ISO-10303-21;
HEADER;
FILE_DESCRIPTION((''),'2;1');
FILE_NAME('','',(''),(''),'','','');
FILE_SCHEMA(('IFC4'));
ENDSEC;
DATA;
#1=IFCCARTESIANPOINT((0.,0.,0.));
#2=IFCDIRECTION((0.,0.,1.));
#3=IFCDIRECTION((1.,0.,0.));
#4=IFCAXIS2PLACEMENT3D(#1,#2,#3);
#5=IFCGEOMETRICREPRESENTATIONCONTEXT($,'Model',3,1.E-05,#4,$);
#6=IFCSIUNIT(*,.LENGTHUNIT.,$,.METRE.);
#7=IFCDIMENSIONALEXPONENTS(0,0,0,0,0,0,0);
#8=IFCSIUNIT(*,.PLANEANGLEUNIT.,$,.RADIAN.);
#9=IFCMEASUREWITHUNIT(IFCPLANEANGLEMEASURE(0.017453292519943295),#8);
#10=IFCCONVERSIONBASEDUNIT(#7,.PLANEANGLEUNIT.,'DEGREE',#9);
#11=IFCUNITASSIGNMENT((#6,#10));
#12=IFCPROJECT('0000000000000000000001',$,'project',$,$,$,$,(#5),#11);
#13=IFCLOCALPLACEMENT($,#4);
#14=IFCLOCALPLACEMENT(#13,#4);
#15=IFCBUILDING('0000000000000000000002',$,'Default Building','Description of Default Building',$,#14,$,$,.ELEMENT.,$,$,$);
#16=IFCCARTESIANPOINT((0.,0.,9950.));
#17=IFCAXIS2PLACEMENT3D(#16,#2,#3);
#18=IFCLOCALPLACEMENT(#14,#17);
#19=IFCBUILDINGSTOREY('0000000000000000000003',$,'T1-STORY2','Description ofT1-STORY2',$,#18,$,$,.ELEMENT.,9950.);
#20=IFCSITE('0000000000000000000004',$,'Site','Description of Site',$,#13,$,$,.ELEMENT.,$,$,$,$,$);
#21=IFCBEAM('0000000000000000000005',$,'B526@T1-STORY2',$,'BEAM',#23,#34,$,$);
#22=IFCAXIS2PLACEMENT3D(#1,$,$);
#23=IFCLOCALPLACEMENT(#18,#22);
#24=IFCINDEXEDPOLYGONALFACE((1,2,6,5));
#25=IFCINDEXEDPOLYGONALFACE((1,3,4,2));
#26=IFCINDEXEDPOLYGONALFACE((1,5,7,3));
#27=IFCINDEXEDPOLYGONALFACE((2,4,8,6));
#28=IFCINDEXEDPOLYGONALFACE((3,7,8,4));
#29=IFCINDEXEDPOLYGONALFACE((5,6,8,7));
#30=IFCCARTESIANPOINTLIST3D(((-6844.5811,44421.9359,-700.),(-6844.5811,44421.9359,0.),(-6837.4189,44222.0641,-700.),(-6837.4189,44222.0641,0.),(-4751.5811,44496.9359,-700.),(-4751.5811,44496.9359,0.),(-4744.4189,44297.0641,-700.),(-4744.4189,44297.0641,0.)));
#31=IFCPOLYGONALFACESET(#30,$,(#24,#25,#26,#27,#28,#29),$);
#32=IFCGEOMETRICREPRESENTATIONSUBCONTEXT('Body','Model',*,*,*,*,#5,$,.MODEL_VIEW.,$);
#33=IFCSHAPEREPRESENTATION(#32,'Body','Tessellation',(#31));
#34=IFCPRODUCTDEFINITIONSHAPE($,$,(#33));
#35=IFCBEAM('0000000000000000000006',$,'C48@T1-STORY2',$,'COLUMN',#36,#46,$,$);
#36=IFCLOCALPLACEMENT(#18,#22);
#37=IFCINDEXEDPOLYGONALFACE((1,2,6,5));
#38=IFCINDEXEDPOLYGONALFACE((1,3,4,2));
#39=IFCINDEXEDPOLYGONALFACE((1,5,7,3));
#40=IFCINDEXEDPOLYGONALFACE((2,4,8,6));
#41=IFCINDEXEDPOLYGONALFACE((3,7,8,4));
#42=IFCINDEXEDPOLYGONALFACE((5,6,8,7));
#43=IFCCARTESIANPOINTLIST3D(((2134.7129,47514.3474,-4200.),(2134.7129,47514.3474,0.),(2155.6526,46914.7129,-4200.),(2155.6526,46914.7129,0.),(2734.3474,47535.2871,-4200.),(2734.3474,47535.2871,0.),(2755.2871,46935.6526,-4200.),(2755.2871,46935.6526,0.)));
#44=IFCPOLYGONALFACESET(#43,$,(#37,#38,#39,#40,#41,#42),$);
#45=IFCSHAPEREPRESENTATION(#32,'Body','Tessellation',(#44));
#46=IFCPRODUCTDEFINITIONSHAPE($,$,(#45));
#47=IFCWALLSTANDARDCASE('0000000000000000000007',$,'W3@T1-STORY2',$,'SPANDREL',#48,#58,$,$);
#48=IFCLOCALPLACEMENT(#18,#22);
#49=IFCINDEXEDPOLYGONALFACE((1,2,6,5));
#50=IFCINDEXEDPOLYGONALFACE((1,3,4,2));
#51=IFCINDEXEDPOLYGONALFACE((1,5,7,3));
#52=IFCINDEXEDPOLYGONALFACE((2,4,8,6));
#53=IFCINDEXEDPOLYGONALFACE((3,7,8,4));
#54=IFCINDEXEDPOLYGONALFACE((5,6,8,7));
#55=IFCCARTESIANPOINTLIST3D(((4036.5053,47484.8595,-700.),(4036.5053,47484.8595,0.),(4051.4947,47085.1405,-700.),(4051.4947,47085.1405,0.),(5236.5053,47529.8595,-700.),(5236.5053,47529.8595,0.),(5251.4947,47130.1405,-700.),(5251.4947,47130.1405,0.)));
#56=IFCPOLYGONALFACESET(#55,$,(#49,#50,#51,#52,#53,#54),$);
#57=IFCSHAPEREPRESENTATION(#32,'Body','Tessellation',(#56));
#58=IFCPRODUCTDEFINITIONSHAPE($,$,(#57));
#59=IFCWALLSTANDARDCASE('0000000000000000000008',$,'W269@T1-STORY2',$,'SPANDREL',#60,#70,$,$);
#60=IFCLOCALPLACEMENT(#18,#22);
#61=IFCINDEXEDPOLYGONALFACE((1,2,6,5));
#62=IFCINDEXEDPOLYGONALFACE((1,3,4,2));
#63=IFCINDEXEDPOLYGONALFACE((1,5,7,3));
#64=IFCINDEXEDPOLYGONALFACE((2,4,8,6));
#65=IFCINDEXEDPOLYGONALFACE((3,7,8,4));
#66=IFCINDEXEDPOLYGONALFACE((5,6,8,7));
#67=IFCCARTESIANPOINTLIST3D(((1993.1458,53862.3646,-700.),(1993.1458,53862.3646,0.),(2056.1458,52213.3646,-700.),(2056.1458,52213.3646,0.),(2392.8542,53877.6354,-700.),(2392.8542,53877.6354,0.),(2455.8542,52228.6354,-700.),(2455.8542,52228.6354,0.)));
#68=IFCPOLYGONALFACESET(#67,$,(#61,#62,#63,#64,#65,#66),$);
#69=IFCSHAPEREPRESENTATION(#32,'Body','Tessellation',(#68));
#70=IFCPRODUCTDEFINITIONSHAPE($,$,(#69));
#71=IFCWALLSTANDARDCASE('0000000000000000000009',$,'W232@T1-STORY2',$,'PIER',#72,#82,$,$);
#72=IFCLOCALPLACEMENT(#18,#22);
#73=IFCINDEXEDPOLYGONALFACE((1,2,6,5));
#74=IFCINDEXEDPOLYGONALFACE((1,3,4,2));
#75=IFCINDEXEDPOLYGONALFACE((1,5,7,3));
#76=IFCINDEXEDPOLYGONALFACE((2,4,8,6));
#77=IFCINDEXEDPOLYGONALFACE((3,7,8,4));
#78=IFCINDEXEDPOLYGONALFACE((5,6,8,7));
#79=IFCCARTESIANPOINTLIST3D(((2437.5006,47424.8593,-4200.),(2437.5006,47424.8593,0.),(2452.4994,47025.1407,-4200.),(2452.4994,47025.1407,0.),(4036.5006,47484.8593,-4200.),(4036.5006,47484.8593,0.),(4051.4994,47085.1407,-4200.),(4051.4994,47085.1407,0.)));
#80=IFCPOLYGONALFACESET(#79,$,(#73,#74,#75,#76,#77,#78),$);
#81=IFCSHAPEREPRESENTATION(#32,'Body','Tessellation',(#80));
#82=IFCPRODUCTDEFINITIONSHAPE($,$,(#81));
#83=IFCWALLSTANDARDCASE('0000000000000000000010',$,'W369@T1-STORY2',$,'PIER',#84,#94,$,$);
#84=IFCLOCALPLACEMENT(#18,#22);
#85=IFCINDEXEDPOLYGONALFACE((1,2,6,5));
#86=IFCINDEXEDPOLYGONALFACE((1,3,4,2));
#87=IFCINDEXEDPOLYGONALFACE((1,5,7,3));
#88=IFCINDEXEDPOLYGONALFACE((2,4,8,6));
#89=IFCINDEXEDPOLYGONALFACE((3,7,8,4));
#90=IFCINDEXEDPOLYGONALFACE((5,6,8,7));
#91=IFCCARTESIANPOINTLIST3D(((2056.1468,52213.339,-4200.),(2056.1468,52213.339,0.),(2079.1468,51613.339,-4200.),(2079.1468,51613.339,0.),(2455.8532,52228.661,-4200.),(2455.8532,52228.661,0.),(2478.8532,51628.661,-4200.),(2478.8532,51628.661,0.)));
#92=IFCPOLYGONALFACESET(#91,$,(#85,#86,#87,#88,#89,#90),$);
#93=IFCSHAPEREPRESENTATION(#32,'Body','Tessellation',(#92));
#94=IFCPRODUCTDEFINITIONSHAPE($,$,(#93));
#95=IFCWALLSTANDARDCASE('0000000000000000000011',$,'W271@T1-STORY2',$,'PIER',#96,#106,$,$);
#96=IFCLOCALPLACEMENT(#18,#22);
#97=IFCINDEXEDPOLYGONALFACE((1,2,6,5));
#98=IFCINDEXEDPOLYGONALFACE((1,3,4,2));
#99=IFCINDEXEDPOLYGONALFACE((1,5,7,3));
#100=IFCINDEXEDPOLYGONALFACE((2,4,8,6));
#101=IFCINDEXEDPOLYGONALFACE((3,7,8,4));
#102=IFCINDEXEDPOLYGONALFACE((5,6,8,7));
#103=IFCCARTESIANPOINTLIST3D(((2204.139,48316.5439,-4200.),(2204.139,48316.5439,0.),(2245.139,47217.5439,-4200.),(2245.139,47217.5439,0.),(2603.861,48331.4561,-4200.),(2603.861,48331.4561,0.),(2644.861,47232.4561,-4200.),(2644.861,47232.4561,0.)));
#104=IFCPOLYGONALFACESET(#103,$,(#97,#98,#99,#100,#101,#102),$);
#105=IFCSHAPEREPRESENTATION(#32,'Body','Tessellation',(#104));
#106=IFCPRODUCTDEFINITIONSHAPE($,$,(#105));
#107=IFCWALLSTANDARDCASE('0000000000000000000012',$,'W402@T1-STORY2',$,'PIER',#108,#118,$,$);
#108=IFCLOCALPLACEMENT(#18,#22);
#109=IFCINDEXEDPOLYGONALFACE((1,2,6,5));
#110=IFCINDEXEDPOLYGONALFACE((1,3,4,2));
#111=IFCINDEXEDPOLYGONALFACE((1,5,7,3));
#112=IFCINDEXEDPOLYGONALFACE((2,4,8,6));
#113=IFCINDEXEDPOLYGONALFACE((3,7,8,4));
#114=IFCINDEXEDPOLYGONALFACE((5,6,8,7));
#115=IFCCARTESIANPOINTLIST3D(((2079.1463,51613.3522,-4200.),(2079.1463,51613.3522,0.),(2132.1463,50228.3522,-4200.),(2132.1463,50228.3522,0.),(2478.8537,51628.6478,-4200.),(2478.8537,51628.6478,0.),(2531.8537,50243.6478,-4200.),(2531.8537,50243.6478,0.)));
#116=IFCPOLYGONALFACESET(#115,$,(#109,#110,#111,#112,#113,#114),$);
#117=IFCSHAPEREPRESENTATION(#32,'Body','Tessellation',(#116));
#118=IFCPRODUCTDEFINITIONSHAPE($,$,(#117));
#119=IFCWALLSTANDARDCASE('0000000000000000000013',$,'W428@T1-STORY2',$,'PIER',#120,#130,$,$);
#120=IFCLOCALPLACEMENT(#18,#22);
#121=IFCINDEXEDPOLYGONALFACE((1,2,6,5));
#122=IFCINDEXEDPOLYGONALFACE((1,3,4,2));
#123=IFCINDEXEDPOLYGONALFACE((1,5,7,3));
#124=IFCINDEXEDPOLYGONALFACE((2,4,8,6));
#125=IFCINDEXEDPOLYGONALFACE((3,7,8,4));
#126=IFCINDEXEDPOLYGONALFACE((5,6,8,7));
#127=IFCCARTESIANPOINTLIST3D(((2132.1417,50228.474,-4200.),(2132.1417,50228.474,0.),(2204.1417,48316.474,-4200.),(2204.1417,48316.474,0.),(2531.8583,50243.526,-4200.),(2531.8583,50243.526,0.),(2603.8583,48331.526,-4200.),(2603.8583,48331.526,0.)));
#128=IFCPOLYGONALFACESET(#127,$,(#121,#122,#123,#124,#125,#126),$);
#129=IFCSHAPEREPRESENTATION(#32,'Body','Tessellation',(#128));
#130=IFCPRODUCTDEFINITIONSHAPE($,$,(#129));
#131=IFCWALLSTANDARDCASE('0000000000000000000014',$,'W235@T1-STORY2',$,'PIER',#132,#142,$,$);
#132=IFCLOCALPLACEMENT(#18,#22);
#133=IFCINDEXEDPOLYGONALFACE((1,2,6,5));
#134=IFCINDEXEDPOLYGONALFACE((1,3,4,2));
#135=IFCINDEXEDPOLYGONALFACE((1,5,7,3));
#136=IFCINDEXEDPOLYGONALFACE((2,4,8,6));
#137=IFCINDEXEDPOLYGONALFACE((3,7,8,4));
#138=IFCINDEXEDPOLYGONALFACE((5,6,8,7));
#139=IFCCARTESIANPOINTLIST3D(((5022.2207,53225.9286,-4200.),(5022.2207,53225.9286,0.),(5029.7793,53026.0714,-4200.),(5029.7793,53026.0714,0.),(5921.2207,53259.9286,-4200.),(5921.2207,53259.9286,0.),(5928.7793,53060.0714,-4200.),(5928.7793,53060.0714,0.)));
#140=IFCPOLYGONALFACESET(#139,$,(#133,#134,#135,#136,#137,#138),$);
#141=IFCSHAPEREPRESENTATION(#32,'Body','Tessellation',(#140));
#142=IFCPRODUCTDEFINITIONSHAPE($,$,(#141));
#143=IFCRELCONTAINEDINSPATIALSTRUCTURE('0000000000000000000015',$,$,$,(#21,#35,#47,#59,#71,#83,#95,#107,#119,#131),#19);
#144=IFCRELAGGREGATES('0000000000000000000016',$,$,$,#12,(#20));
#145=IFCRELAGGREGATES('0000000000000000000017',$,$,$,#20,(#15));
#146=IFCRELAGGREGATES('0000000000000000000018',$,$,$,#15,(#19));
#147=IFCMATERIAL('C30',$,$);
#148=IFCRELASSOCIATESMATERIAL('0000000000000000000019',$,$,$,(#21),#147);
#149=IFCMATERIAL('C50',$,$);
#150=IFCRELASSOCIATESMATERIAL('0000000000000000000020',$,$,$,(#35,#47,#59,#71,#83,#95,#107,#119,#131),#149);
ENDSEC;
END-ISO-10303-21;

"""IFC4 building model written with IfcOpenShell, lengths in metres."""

from ifc_helpers import new_model, entity, si_unit, converted_unit, frame, origin_with_axes, place, context, subcontext, project, spatial, indexed_curve, rectangle, outline, extrude, material, element, save


model = new_model("IFC4")

# Units and contexts
model_context = context("Model", 3, precision=1e-05, world=origin_with_axes())
body_context = subcontext(model_context, "Body", "Model", "MODEL_VIEW")
ifc_project = project(units=[si_unit("LENGTHUNIT", "METRE"), converted_unit("PLANEANGLEUNIT", "DEGREE", entity("IfcPlaneAngleMeasure", 0.017453292519943295), si_unit("PLANEANGLEUNIT", "RADIAN"), dimensions=[0, 0, 0, 0, 0, 0, 0])], contexts=[model_context])

# Site, building, storey
site_placement = place(None, origin_with_axes())
site = spatial("IfcSite", under=ifc_project, at=site_placement, Name="Site", Description="Description of Site", CompositionType="ELEMENT")
building_placement = place(site_placement, origin_with_axes())
building = spatial("IfcBuilding", under=site, at=building_placement, Name="Default Building", Description="Description of Default Building", CompositionType="ELEMENT")
storey_placement = place(building_placement, frame((0.0, 0.0, 9950.0), z_axis=(0.0, 0.0, 1.0), x_axis=(1.0, 0.0, 0.0)))
storey = spatial("IfcBuildingStorey", under=building, at=storey_placement, Name="T1-STORY2", Description="Description ofT1-STORY2", CompositionType="ELEMENT", Elevation=9950.0)

# Beams
ifc_material_1 = material(Name="C30")
beam_1_placement = place(storey_placement, frame((-6841.0, 44322.0, -350.0), z_axis=(0.999359, 0.035811, 0.0), x_axis=(-0.035811, 0.999359, 0.0)))
element("IfcBeam", 1, at=beam_1_placement, inside=storey, material=ifc_material_1, Name="B526@T1-STORY2", ObjectType="BEAM", context=body_context, shape_type="SweptSolid", body=[
    extrude(rectangle(XDim=200.0, YDim=700.0), origin_with_axes(), (0.0, 0.0, 1.0), 2094.3433),
])
ifc_material_2 = material(Name="C50")
beam_2_placement = place(storey_placement, frame((2445.0, 47225.0, -4200.0), z_axis=(0.0, 0.0, 1.0), x_axis=(-0.999391, -0.034899, 0.0)))
element("IfcBeam", 2, at=beam_2_placement, inside=storey, material=ifc_material_2, Name="C48@T1-STORY2", ObjectType="COLUMN", context=body_context, shape_type="SweptSolid", body=[
    extrude(rectangle(XDim=600.0, YDim=600.0), origin_with_axes(), (0.0, 0.0, 1.0), 4200.0),
])

# Walls
wall_1_placement = place(storey_placement, frame((4044.0, 47285.0, -700.0), z_axis=(0.0, 0.0, 1.0), x_axis=(0.999298, 0.037474, 0.0)))
element("IfcWallStandardCase", 3, at=wall_1_placement, inside=storey, material=ifc_material_2, Name="W3@T1-STORY2", ObjectType="SPANDREL", context=body_context, shape_type="SweptSolid", body=[
    extrude(outline(indexed_curve([(0.0, -200.0), (0.0, 200.0), (1200.8435, 200.0), (1200.8435, -200.0), (0.0, -200.0)], self_intersect=False)), origin_with_axes(), (0.0, 0.0, 1.0), 700.0),
])
wall_2_placement = place(storey_placement, frame((2193.0, 53870.0, -700.0), z_axis=(0.0, 0.0, 1.0), x_axis=(0.038177, -0.999271, 0.0)))
element("IfcWallStandardCase", 4, at=wall_2_placement, inside=storey, material=ifc_material_2, Name="W269@T1-STORY2", ObjectType="SPANDREL", context=body_context, shape_type="SweptSolid", body=[
    extrude(outline(indexed_curve([(0.0, -200.0), (0.0, 200.0), (1650.203, 200.0), (1650.203, -200.0), (0.0, -200.0)], self_intersect=False)), origin_with_axes(), (0.0, 0.0, 1.0), 700.0),
])
wall_3_placement = place(storey_placement, frame((2445.0, 47225.0, -4200.0), z_axis=(0.0, 0.0, 1.0), x_axis=(0.999297, 0.037497, 0.0)))
element("IfcWallStandardCase", 5, at=wall_3_placement, inside=storey, material=ifc_material_2, Name="W232@T1-STORY2", ObjectType="PIER", context=body_context, shape_type="SweptSolid", body=[
    extrude(outline(indexed_curve([(0.0, -200.0), (0.0, 200.0), (1600.1253, 200.0), (1600.1253, -200.0), (0.0, -200.0)], self_intersect=False)), origin_with_axes(), (0.0, 0.0, 1.0), 4200.0),
])
wall_4_placement = place(storey_placement, frame((2256.0, 52221.0, -4200.0), z_axis=(0.0, 0.0, 1.0), x_axis=(0.038305, -0.999266, 0.0)))
element("IfcWallStandardCase", 6, at=wall_4_placement, inside=storey, material=ifc_material_2, Name="W369@T1-STORY2", ObjectType="PIER", context=body_context, shape_type="SweptSolid", body=[
    extrude(outline(indexed_curve([(0.0, -200.0), (0.0, 200.0), (600.4407, 200.0), (600.4407, -200.0), (0.0, -200.0)], self_intersect=False)), origin_with_axes(), (0.0, 0.0, 1.0), 4200.0),
])
wall_5_placement = place(storey_placement, frame((2404.0, 48324.0, -4200.0), z_axis=(0.0, 0.0, 1.0), x_axis=(0.037281, -0.999305, 0.0)))
element("IfcWallStandardCase", 7, at=wall_5_placement, inside=storey, material=ifc_material_2, Name="W271@T1-STORY2", ObjectType="PIER", context=body_context, shape_type="SweptSolid", body=[
    extrude(outline(indexed_curve([(0.0, -200.0), (0.0, 200.0), (1099.7645, 200.0), (1099.7645, -200.0), (0.0, -200.0)], self_intersect=False)), origin_with_axes(), (0.0, 0.0, 1.0), 4200.0),
])
wall_6_placement = place(storey_placement, frame((2279.0, 51621.0, -4200.0), z_axis=(0.0, 0.0, 1.0), x_axis=(0.038239, -0.999269, 0.0)))
element("IfcWallStandardCase", 8, at=wall_6_placement, inside=storey, material=ifc_material_2, Name="W402@T1-STORY2", ObjectType="PIER", context=body_context, shape_type="SweptSolid", body=[
    extrude(outline(indexed_curve([(0.0, -200.0), (0.0, 200.0), (1386.0137, 200.0), (1386.0137, -200.0), (0.0, -200.0)], self_intersect=False)), origin_with_axes(), (0.0, 0.0, 1.0), 4200.0),
])
wall_7_placement = place(storey_placement, frame((2332.0, 50236.0, -4200.0), z_axis=(0.0, 0.0, 1.0), x_axis=(0.03763, -0.999292, 0.0)))
element("IfcWallStandardCase", 9, at=wall_7_placement, inside=storey, material=ifc_material_2, Name="W428@T1-STORY2", ObjectType="PIER", context=body_context, shape_type="SweptSolid", body=[
    extrude(outline(indexed_curve([(0.0, -200.0), (0.0, 200.0), (1913.3552, 200.0), (1913.3552, -200.0), (0.0, -200.0)], self_intersect=False)), origin_with_axes(), (0.0, 0.0, 1.0), 4200.0),
])
wall_8_placement = place(storey_placement, frame((5026.0, 53126.0, -4200.0), z_axis=(0.0, 0.0, 1.0), x_axis=(0.999286, 0.037793, 0.0)))
element("IfcWallStandardCase", 10, at=wall_8_placement, inside=storey, material=ifc_material_2, Name="W235@T1-STORY2", ObjectType="PIER", context=body_context, shape_type="SweptSolid", body=[
    extrude(outline(indexed_curve([(0.0, -100.0), (0.0, 100.0), (899.6427, 100.0), (899.6427, -100.0), (0.0, -100.0)], self_intersect=False)), origin_with_axes(), (0.0, 0.0, 1.0), 4200.0),
])

save(model, "model.ifc")
